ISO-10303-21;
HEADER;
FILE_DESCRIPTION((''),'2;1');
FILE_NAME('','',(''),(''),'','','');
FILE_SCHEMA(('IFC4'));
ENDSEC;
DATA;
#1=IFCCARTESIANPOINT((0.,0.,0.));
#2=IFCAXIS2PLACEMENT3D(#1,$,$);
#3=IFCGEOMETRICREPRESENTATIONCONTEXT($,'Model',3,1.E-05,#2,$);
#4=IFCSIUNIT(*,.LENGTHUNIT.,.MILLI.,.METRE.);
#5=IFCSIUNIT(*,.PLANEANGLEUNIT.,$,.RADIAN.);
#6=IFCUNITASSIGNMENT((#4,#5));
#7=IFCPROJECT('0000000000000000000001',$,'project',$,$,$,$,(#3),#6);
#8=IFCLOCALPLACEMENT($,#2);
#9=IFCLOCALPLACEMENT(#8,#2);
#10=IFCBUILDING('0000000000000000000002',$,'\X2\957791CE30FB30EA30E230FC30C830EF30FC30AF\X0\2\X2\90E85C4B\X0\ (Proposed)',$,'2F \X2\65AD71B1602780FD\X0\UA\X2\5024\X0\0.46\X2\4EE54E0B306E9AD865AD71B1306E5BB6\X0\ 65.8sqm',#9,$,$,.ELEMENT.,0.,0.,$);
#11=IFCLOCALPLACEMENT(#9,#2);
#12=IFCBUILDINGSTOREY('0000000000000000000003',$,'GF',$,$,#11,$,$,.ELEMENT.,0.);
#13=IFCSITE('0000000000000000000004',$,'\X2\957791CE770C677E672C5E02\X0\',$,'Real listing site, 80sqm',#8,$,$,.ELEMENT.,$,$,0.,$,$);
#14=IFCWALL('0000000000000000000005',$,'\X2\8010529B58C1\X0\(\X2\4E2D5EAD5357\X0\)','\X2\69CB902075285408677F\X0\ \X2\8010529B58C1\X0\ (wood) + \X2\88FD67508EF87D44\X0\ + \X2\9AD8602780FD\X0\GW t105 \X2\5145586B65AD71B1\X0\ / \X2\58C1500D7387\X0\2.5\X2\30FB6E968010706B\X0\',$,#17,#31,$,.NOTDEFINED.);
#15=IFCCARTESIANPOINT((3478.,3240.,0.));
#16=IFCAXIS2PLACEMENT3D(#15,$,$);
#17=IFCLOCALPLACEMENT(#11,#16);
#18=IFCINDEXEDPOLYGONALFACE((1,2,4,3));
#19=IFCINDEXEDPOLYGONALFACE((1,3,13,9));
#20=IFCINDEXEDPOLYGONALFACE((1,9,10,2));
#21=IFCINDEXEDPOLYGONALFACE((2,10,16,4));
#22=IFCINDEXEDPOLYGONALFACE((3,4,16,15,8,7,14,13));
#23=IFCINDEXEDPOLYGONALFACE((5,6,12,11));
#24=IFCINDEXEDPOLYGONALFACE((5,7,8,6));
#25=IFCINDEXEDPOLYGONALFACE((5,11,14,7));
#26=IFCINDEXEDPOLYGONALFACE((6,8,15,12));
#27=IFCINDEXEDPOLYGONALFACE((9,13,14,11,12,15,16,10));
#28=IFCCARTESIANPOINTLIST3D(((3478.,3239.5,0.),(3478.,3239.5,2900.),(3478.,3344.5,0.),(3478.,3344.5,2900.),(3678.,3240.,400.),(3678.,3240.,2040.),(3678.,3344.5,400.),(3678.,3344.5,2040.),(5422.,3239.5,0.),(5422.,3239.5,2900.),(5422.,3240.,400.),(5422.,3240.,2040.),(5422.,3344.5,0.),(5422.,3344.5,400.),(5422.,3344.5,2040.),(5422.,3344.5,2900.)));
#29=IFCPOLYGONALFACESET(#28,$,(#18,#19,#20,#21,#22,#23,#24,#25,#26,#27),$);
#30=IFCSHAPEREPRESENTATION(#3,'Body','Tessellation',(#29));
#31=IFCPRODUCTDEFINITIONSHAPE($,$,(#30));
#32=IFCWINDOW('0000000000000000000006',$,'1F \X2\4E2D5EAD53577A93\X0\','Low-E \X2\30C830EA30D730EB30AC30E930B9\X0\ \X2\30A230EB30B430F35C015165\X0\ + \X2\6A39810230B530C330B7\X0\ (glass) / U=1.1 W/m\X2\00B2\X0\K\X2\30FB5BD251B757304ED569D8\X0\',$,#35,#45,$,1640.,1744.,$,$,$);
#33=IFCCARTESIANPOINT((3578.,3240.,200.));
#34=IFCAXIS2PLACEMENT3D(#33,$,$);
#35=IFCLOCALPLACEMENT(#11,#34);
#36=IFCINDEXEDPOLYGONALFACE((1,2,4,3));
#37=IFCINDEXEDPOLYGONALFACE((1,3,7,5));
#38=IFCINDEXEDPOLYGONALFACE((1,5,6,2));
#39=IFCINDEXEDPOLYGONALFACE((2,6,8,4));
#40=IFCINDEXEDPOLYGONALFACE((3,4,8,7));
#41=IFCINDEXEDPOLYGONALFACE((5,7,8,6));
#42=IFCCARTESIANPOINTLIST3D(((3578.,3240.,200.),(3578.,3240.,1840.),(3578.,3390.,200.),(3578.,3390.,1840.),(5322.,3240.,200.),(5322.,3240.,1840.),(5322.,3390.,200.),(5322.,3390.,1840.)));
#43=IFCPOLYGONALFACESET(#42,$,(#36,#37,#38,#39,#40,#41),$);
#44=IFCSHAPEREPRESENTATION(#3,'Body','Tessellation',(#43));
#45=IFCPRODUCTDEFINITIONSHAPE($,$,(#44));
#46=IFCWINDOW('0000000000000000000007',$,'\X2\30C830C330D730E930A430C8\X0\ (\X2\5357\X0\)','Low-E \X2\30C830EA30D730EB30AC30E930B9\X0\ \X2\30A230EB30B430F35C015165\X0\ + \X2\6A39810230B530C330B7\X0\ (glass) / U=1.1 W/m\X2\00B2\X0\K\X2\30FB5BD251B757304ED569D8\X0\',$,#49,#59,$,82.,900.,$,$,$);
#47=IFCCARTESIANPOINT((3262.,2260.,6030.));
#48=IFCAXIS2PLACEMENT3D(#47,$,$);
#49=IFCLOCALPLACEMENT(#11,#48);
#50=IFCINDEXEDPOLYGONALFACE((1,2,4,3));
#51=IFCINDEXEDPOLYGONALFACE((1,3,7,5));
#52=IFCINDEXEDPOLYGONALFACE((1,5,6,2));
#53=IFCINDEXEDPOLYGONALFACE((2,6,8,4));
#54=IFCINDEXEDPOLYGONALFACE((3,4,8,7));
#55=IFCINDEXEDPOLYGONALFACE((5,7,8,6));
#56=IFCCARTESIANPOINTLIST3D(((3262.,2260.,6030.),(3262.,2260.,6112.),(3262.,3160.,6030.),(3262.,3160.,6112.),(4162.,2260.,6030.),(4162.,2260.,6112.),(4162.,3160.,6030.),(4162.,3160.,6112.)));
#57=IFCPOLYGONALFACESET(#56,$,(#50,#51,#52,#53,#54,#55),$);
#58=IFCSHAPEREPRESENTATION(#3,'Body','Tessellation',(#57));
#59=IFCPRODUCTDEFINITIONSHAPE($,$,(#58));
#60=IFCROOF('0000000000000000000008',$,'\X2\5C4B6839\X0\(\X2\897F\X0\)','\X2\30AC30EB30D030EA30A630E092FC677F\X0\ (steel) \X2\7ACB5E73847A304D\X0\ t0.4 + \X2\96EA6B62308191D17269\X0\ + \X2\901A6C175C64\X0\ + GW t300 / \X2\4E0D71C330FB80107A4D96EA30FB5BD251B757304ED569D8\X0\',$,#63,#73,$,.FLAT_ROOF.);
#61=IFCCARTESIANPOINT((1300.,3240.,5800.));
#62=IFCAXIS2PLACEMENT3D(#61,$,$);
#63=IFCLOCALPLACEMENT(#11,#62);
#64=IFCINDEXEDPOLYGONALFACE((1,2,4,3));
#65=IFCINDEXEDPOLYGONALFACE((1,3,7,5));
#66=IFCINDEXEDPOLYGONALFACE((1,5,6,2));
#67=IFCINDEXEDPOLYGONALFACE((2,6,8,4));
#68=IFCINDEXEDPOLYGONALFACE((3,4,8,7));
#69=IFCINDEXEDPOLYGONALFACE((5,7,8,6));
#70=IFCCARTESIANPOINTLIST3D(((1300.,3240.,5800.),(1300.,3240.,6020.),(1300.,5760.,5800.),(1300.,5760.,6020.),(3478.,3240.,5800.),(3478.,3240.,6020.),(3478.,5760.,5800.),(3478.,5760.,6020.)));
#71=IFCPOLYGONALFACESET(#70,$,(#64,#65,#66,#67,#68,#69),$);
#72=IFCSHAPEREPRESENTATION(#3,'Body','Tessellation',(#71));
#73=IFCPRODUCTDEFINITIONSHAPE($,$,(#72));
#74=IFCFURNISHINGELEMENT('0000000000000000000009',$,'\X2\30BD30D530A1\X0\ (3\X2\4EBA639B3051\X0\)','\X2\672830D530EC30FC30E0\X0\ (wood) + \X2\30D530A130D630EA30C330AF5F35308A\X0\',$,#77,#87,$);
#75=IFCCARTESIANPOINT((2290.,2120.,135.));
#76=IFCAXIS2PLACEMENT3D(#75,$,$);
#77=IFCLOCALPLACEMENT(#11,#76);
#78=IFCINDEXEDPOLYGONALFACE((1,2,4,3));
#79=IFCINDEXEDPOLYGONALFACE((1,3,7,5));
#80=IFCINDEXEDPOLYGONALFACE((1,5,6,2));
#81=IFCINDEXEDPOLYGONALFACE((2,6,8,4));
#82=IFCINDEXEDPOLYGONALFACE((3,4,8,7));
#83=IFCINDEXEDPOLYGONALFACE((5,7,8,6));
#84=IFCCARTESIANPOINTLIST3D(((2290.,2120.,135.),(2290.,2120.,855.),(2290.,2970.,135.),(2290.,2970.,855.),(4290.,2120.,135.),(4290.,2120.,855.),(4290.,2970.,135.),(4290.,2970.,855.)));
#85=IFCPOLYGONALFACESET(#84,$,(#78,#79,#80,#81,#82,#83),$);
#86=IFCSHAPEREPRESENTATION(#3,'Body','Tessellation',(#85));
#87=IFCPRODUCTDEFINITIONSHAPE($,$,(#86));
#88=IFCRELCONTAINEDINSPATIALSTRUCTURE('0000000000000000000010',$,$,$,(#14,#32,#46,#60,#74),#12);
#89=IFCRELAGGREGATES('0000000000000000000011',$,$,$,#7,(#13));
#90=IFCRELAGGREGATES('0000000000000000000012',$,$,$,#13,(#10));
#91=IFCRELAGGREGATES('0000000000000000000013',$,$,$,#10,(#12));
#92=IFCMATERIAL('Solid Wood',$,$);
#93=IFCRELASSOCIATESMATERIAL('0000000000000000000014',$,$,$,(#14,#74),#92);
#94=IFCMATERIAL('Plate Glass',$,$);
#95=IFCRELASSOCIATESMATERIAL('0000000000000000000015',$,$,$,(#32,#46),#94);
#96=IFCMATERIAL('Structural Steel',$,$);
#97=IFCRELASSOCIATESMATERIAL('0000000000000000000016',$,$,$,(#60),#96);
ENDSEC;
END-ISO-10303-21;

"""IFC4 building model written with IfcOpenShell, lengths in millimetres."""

from ifc_helpers import new_model, si_unit, frame, frame_2d, origin, place, context, project, spatial, rectangle, extrude, material, element, fill, save


model = new_model("IFC4")

# Units and contexts
model_context = context("Model", 3, precision=1e-05, world=origin())
ifc_project = project(units=[si_unit("LENGTHUNIT", "METRE", prefix="MILLI"), si_unit("PLANEANGLEUNIT", "RADIAN")], contexts=[model_context])

# Site, building, storey
site_placement = place(None, origin())
site = spatial("IfcSite", under=ifc_project, at=site_placement, Name="長野県松本市", ObjectType="Real listing site, 80sqm", CompositionType="ELEMENT", RefElevation=0.0)
building_placement = place(site_placement, origin())
building = spatial("IfcBuilding", under=site, at=building_placement, Name="長野・リモートワーク2部屋 (Proposed)", ObjectType="2F 断熱性能UA値0.46以下の高断熱の家 65.8sqm", CompositionType="ELEMENT", ElevationOfRefHeight=0.0, ElevationOfTerrain=0.0)
storey_placement = place(building_placement, origin())
storey = spatial("IfcBuildingStorey", under=building, at=storey_placement, Name="GF", CompositionType="ELEMENT", Elevation=0.0)

# Shared definitions
ifc_material_1 = material(Name="Solid Wood")

# Wall, opening, window
wall_placement = place(storey_placement, frame((3478.0, 3240.0, 0.0)))
wall = element("IfcWall", 1, at=wall_placement, inside=storey, material=ifc_material_1, Name="耐力壁(中庭南)", Description="構造用合板 耐力壁 (wood) + 製材軸組 + 高性能GW t105 充填断熱 / 壁倍率2.5・準耐火", PredefinedType="NOTDEFINED", context=model_context, shape_type="SweptSolid", body=[
    extrude(rectangle(XDim=1944.0, YDim=105.0, at=frame_2d((972.0, 52.0))), frame((3478.0, 3240.0, 0.0)), (0.0, 0.0, 1.0), 2900.0),
])
opening_placement = place(storey_placement, frame((3578.0, 3240.0, 200.0)))
opening = element("IfcOpeningElement", 2, at=opening_placement, cuts=wall, PredefinedType="NOTDEFINED", context=model_context, shape_type="SweptSolid", body=[
    extrude(rectangle(XDim=1744.0, YDim=150.0, at=frame_2d((872.0, 75.0))), frame((3578.0, 3240.0, 200.0)), (0.0, 0.0, 1.0), 1640.0),
])
ifc_material_2 = material(Name="Plate Glass")
window_1_placement = place(storey_placement, frame((3578.0, 3240.0, 200.0)))
window_1 = element("IfcWindow", 3, at=window_1_placement, inside=storey, material=ifc_material_2, Name="1F 中庭南窓", Description="Low-E トリプルガラス アルゴン封入 + 樹脂サッシ (glass) / U=1.1 W/m²K・寒冷地仕様", OverallHeight=1640.0, OverallWidth=1744.0, context=model_context, shape_type="SweptSolid", body=[
    extrude(rectangle(XDim=1744.0, YDim=150.0, at=frame_2d((872.0, 75.0))), frame((3578.0, 3240.0, 200.0)), (0.0, 0.0, 1.0), 1640.0),
])
fill(opening, window_1)

# Window
window_2_placement = place(storey_placement, frame((3262.0, 2260.0, 6030.0)))
element("IfcWindow", 4, at=window_2_placement, inside=storey, material=ifc_material_2, Name="トップライト (南)", Description="Low-E トリプルガラス アルゴン封入 + 樹脂サッシ (glass) / U=1.1 W/m²K・寒冷地仕様", OverallHeight=82.0, OverallWidth=900.0, context=model_context, shape_type="SweptSolid", body=[
    extrude(rectangle(XDim=900.0, YDim=900.0, at=frame_2d((450.0, 450.0))), frame((3262.0, 2260.0, 6030.0)), (0.0, 0.0, 1.0), 82.0),
])

# Roof
ifc_material_3 = material(Name="Structural Steel")
for number, where, name in (
    (5, (1300.0, 3240.0, 5800.0), "屋根(西)"),
):
    element("IfcRoof", number, at=place(storey_placement, frame(where)), inside=storey, material=ifc_material_3, Name=name, Description="ガルバリウム鋼板 (steel) 立平葺き t0.4 + 雪止め金物 + 通気層 + GW t300 / 不燃・耐積雪・寒冷地仕様", PredefinedType="FLAT_ROOF", context=model_context, shape_type="SweptSolid", body=[
        extrude(rectangle(XDim=2178.0, YDim=2520.0, at=frame_2d((1089.0, 1260.0))), frame((1300.0, 3240.0, 5800.0)), (0.0, 0.0, 1.0), 220.0),
    ])

# Furnishing element
furnishing_placement = place(storey_placement, frame((2290.0, 2120.0, 135.0)))
element("IfcFurnishingElement", 6, at=furnishing_placement, inside=storey, material=ifc_material_1, Name="ソファ (3人掛け)", Description="木フレーム (wood) + ファブリック張り", context=model_context, shape_type="SweptSolid", body=[
    extrude(rectangle(XDim=2000.0, YDim=850.0, at=frame_2d((1000.0, 425.0))), frame((2290.0, 2120.0, 135.0)), (0.0, 0.0, 1.0), 720.0),
])

save(model, "model.ifc")
